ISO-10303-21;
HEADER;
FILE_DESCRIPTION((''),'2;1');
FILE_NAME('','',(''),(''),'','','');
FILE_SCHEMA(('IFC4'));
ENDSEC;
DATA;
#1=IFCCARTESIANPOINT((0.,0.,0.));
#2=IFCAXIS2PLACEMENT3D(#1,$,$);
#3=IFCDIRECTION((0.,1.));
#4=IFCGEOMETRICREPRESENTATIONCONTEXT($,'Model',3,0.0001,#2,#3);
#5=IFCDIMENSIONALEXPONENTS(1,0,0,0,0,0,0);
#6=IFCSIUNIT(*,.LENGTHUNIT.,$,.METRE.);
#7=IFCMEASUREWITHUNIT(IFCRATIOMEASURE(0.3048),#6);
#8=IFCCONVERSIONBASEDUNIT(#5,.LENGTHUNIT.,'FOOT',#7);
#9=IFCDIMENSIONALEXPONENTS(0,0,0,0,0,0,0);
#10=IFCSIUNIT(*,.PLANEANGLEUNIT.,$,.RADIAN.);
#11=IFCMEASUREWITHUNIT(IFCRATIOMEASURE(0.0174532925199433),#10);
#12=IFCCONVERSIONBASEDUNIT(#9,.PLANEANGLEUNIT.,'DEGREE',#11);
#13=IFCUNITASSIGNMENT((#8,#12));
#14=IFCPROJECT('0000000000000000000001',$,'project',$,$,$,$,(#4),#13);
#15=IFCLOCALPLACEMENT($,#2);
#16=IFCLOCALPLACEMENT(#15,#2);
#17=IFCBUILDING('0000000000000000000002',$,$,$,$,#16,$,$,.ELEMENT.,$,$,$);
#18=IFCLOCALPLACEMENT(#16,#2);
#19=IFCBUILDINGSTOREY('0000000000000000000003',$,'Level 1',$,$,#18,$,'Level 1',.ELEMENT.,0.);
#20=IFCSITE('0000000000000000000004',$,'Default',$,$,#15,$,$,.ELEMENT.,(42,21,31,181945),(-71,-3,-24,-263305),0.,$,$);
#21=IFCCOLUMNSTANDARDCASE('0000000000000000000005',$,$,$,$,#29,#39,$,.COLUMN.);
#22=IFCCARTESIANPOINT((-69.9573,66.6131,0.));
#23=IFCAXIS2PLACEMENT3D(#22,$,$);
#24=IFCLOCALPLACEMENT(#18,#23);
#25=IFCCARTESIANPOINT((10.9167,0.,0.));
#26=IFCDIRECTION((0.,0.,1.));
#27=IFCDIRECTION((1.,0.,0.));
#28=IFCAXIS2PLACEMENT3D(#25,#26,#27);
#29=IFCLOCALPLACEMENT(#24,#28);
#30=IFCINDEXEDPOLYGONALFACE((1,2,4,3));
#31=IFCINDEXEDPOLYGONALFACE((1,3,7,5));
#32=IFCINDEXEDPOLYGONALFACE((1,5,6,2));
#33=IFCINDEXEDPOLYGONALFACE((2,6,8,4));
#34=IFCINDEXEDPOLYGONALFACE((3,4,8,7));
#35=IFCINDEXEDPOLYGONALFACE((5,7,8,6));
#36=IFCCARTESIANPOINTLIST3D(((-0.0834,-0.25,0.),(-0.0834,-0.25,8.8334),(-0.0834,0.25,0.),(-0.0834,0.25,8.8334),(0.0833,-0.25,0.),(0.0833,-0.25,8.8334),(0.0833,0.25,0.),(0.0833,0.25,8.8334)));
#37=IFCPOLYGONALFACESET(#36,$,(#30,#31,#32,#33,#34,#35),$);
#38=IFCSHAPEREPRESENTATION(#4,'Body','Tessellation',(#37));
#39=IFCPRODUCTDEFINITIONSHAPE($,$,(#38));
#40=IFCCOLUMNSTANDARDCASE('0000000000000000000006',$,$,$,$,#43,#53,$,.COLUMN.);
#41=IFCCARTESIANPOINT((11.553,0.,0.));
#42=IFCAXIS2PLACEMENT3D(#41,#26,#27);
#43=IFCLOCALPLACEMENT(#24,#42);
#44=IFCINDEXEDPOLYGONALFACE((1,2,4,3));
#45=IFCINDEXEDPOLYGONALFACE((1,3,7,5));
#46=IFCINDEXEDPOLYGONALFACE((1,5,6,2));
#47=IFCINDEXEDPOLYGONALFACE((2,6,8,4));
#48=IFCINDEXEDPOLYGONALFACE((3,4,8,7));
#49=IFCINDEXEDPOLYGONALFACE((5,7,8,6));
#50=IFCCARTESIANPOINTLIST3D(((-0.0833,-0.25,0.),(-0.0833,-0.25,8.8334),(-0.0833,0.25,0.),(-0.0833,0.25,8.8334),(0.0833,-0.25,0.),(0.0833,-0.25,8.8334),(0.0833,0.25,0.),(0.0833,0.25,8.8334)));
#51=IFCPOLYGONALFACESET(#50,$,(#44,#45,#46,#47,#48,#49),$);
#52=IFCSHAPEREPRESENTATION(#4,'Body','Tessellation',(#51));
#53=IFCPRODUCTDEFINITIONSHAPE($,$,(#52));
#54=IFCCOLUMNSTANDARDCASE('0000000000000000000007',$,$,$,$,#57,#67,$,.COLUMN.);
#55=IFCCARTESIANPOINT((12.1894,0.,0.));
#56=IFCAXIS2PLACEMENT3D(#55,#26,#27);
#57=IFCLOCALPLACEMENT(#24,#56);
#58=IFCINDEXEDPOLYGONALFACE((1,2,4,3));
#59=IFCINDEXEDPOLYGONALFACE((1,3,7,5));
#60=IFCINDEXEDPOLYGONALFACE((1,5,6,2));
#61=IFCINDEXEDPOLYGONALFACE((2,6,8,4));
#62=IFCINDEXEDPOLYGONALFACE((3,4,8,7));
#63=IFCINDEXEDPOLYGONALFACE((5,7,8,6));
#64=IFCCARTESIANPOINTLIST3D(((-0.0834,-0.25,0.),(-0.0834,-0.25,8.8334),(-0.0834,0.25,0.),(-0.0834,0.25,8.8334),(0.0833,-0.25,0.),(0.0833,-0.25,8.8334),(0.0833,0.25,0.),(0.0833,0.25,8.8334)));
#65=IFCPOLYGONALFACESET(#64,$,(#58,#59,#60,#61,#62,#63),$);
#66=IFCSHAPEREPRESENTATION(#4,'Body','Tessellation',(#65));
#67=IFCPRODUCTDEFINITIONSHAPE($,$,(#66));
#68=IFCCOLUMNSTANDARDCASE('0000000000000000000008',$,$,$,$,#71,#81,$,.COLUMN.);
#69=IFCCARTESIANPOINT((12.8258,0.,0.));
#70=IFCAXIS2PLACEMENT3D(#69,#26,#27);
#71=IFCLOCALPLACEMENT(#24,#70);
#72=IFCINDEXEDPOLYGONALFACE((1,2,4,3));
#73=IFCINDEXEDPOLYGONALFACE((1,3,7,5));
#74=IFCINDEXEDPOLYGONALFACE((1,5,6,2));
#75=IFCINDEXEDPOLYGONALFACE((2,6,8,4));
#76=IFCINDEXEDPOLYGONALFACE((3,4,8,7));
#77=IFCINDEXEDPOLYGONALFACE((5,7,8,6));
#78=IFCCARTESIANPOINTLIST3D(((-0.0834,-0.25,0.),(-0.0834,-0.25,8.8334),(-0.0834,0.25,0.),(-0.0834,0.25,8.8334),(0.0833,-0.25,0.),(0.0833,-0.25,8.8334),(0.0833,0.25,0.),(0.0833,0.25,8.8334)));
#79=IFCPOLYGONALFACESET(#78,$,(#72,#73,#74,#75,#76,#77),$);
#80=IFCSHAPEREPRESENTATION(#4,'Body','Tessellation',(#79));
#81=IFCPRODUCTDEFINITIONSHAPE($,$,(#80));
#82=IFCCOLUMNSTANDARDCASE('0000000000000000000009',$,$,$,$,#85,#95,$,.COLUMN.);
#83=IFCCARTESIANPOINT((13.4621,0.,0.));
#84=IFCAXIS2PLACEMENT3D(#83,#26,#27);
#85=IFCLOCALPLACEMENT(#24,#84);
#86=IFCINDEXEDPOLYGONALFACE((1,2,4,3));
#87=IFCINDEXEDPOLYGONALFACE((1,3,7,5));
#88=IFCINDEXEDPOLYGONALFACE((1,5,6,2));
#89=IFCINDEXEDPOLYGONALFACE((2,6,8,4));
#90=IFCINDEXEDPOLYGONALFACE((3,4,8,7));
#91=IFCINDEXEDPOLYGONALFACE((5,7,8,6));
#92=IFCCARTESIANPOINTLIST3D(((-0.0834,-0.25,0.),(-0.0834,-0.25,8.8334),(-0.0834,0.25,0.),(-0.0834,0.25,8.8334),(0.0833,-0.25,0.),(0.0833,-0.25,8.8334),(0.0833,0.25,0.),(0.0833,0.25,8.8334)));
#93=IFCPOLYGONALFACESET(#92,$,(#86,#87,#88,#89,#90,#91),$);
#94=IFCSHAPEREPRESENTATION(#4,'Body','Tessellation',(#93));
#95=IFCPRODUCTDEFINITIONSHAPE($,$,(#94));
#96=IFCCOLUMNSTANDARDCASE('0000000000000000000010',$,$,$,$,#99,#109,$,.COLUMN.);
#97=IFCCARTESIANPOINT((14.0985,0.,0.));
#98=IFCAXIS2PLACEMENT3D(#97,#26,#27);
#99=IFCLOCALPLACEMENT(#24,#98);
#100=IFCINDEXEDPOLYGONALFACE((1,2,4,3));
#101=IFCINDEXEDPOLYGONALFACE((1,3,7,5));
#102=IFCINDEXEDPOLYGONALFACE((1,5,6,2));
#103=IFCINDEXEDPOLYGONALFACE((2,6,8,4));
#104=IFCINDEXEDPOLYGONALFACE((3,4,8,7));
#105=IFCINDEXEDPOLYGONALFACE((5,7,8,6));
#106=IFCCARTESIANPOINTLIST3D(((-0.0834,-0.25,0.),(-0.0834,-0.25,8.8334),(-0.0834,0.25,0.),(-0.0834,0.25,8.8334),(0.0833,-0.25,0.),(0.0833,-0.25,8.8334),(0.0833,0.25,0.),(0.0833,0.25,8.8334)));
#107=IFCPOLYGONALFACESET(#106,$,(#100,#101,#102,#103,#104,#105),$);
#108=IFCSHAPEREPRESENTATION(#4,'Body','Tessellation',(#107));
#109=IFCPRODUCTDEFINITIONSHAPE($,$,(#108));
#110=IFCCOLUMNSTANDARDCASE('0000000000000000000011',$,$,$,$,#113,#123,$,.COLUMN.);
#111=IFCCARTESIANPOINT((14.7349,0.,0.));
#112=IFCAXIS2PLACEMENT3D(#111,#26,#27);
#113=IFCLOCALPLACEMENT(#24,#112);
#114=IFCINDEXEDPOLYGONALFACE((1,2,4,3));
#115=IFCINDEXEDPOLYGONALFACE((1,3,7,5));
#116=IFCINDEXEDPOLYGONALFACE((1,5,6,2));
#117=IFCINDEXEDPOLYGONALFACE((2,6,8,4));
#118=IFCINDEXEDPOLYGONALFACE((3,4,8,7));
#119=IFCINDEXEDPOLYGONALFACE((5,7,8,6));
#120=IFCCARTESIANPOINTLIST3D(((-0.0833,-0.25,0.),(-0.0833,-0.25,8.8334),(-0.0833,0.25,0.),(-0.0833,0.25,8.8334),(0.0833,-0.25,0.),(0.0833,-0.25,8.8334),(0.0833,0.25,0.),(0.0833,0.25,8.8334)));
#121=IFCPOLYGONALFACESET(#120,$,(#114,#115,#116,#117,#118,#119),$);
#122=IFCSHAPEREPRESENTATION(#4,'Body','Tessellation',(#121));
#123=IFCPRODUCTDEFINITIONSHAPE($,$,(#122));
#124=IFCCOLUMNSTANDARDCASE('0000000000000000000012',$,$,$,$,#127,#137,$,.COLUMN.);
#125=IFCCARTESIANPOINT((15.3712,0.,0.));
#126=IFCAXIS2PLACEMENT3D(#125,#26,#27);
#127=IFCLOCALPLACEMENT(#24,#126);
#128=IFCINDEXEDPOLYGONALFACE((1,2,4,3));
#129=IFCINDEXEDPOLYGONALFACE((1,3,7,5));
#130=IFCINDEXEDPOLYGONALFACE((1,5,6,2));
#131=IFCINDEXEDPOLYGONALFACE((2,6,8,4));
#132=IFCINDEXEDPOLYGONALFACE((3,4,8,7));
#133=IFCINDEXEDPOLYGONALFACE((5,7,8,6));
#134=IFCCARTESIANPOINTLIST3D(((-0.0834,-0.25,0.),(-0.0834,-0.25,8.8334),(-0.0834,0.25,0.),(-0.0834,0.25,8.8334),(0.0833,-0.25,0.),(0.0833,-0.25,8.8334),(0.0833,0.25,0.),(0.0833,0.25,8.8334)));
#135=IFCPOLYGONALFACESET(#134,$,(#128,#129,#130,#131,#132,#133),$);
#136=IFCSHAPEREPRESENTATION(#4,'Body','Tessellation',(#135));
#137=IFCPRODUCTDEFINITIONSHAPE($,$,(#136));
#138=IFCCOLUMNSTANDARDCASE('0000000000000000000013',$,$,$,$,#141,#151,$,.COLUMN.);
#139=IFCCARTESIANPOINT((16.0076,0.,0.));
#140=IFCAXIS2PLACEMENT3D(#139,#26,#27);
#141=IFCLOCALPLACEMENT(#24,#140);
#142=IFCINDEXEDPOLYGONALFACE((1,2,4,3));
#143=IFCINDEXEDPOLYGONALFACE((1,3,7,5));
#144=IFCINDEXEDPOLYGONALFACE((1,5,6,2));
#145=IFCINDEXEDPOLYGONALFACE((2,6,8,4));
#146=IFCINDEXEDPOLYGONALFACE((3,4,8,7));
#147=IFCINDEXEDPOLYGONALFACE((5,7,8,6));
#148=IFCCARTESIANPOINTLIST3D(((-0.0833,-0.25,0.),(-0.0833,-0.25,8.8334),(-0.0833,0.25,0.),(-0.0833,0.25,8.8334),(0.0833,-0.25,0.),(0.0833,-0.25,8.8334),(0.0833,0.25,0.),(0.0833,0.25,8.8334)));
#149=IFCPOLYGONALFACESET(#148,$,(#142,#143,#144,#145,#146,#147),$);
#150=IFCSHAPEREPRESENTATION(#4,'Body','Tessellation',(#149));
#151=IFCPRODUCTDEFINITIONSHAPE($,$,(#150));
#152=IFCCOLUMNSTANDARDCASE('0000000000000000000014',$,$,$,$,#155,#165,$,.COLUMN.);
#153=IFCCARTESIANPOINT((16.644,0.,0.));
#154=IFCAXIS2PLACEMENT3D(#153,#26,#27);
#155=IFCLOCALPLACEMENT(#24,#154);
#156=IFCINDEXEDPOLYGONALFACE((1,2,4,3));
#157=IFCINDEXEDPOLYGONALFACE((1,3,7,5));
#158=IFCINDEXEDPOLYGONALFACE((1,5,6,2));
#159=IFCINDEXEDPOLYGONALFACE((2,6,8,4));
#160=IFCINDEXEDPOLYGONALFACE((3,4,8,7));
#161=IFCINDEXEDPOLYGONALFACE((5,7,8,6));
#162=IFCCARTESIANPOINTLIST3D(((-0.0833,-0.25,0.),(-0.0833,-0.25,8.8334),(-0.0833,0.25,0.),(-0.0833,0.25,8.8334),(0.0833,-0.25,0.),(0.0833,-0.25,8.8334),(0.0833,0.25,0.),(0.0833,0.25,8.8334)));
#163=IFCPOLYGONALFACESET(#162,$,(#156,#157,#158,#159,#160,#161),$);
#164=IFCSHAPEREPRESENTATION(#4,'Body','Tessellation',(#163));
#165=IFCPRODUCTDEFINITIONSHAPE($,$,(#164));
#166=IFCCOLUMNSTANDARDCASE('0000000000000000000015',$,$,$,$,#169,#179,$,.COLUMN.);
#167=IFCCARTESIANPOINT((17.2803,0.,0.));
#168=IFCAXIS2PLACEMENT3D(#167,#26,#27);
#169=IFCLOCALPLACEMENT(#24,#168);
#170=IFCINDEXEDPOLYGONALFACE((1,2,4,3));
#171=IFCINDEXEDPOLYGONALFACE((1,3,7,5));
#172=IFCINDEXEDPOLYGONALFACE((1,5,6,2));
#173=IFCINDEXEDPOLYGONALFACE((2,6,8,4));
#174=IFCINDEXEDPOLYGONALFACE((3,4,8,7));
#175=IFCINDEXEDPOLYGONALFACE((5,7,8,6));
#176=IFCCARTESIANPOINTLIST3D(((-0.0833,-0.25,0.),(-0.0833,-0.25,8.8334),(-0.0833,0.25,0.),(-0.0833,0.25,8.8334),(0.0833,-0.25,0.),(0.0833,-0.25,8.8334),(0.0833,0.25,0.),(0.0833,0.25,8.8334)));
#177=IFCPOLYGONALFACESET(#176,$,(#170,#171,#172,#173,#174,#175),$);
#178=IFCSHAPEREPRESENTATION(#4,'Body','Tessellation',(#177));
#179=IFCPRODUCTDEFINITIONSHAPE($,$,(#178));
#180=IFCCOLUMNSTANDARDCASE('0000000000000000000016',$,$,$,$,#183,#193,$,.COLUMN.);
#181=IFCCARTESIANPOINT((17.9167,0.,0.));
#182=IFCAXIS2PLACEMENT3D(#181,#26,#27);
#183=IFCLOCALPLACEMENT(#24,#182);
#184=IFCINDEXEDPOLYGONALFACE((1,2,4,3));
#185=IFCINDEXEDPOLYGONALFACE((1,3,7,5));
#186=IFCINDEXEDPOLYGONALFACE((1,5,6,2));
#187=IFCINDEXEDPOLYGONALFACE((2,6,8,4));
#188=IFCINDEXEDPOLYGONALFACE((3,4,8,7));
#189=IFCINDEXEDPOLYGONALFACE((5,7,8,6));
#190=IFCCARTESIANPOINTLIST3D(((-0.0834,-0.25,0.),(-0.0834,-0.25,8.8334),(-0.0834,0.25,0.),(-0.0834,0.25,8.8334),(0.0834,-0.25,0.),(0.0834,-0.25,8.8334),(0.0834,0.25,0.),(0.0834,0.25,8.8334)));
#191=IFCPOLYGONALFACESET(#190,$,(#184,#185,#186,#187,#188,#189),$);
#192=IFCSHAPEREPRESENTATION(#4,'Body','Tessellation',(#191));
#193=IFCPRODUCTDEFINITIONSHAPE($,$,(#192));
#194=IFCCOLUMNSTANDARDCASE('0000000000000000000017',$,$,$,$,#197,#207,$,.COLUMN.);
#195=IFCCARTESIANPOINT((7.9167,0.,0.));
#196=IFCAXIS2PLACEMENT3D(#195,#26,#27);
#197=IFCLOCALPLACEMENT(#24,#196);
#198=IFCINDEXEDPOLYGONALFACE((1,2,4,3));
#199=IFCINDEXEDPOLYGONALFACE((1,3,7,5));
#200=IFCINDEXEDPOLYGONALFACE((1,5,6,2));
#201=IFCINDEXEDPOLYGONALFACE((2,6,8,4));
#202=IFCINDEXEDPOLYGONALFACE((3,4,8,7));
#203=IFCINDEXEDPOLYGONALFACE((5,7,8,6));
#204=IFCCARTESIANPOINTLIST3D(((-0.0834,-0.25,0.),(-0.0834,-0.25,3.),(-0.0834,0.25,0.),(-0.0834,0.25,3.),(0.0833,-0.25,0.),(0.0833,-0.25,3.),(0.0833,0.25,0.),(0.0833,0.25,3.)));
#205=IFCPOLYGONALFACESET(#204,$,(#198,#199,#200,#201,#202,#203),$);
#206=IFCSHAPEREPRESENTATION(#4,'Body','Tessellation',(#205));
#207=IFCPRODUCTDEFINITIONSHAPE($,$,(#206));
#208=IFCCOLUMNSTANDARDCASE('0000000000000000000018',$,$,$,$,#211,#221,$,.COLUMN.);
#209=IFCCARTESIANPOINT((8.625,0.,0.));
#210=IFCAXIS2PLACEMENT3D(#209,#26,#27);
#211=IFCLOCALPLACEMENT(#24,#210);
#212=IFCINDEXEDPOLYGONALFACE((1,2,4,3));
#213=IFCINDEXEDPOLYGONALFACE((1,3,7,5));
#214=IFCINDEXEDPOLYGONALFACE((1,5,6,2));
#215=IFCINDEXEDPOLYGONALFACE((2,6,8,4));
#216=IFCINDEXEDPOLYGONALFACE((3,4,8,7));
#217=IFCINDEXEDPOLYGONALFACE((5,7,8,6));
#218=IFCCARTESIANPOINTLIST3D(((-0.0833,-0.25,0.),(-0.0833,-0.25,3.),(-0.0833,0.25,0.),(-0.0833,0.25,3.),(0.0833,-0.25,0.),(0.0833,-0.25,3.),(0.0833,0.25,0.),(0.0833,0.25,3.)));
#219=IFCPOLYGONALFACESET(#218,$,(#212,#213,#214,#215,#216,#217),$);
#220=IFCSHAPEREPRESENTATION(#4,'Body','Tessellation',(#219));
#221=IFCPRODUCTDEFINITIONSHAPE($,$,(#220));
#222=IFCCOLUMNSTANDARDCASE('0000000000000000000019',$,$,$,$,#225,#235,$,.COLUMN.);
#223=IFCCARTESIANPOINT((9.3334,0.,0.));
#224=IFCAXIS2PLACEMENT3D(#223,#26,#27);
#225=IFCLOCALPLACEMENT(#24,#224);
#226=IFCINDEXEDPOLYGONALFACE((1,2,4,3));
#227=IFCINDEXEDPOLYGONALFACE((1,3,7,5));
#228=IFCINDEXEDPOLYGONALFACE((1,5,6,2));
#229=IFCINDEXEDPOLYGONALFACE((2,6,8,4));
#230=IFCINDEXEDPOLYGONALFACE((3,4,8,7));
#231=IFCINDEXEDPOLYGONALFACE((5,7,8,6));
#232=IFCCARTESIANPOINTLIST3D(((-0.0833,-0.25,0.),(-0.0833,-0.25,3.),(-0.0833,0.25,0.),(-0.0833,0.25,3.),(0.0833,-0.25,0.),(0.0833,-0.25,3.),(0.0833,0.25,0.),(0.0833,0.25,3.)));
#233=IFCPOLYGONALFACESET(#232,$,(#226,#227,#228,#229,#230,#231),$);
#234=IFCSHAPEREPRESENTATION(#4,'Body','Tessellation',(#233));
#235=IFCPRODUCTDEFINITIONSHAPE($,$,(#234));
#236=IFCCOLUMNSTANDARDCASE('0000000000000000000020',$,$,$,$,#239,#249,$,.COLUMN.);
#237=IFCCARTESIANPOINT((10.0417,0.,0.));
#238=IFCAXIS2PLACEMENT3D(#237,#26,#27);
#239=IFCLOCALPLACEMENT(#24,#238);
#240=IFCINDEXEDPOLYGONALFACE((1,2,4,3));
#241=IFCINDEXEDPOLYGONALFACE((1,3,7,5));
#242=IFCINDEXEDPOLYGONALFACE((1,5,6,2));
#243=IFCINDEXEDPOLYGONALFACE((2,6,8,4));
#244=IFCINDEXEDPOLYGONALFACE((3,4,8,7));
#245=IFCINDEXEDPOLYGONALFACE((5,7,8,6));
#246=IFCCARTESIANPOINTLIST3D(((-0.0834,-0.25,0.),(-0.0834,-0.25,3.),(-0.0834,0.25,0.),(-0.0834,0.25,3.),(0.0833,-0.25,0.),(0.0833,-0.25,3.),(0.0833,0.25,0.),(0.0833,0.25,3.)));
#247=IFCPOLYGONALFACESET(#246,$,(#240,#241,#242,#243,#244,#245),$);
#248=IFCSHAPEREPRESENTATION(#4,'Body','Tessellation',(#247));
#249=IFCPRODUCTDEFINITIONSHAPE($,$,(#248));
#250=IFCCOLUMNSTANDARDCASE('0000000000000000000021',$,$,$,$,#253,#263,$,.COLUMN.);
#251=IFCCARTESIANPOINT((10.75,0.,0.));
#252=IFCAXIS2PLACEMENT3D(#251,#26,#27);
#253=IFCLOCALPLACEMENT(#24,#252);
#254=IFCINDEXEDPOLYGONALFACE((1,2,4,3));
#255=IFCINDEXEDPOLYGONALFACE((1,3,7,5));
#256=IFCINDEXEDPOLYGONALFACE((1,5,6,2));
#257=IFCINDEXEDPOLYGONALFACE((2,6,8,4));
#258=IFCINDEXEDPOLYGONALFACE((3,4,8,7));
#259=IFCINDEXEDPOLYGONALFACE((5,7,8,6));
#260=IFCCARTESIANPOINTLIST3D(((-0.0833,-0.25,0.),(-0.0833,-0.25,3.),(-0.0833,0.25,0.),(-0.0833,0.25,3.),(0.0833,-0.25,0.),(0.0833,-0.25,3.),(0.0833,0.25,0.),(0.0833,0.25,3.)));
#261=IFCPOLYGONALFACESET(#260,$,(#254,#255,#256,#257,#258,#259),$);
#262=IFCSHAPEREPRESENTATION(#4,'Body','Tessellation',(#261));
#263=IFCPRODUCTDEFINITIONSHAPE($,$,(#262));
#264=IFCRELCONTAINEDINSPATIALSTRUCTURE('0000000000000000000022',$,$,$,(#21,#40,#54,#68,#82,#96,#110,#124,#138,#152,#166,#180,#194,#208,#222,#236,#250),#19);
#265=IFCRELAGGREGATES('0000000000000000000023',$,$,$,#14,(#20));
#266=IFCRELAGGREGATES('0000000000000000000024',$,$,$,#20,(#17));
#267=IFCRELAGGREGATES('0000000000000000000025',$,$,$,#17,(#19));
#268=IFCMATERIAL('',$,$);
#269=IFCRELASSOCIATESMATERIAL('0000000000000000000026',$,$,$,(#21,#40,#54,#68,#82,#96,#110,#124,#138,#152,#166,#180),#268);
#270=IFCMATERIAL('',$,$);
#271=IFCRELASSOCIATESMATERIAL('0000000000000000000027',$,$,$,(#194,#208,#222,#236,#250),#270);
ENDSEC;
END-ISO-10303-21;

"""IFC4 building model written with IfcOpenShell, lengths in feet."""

from ifc_helpers import new_model, entity, si_unit, converted_unit, direction, frame, origin, place, context, project, spatial, rectangle, extrude, material, element, save


model = new_model("IFC4")

# Units and contexts
model_context = context("Model", 3, precision=0.0001, world=origin(), true_north=direction((0.0, 1.0)))
ifc_project = project(units=[converted_unit("LENGTHUNIT", "FOOT", entity("IfcRatioMeasure", 0.3048), si_unit("LENGTHUNIT", "METRE"), dimensions=[1, 0, 0, 0, 0, 0, 0]), converted_unit("PLANEANGLEUNIT", "DEGREE", entity("IfcRatioMeasure", 0.0174532925199433), si_unit("PLANEANGLEUNIT", "RADIAN"), dimensions=[0, 0, 0, 0, 0, 0, 0])], contexts=[model_context])

# Site, building, storey
site_placement = place(None, origin())
site = spatial("IfcSite", under=ifc_project, at=site_placement, Name="Default", CompositionType="ELEMENT", RefLatitude=(42, 21, 31, 181945), RefLongitude=(-71, -3, -24, -263305), RefElevation=0.0)
building_placement = place(site_placement, origin())
building = spatial("IfcBuilding", under=site, at=building_placement, CompositionType="ELEMENT")
storey_placement = place(building_placement, origin())
storey = spatial("IfcBuildingStorey", under=building, at=storey_placement, Name="Level 1", LongName="Level 1", CompositionType="ELEMENT", Elevation=0.0)

# Columns
placement_1 = place(storey_placement, frame((-69.9573, 66.6131, 0.0)))
ifc_material_1 = material(Name="")
for number, where, z_axis, x_axis in (
    (1, (10.9167, 0.0, 0.0), (0.0, 0.0, 1.0), (1.0, 0.0, 0.0)),
    (2, (11.553, 0.0, 0.0), (0.0, 0.0, 1.0), (1.0, 0.0, 0.0)),
    (3, (12.1894, 0.0, 0.0), (0.0, 0.0, 1.0), (1.0, 0.0, 0.0)),
    (4, (12.8258, 0.0, 0.0), (0.0, 0.0, 1.0), (1.0, 0.0, 0.0)),
    (5, (13.4621, 0.0, 0.0), (0.0, 0.0, 1.0), (1.0, 0.0, 0.0)),
    (6, (14.0985, 0.0, 0.0), (0.0, 0.0, 1.0), (1.0, 0.0, 0.0)),
    (7, (14.7349, 0.0, 0.0), (0.0, 0.0, 1.0), (1.0, 0.0, 0.0)),
    (8, (15.3712, 0.0, 0.0), (0.0, 0.0, 1.0), (1.0, 0.0, 0.0)),
    (9, (16.0076, 0.0, 0.0), (0.0, 0.0, 1.0), (1.0, 0.0, 0.0)),
    (10, (16.644, 0.0, 0.0), (0.0, 0.0, 1.0), (1.0, 0.0, 0.0)),
    (11, (17.2803, 0.0, 0.0), (0.0, 0.0, 1.0), (1.0, 0.0, 0.0)),
    (12, (17.9167, 0.0, 0.0), (0.0, 0.0, 1.0), (1.0, 0.0, 0.0)),
):
    element("IfcColumnStandardCase", number, at=place(placement_1, frame(where, z_axis=z_axis, x_axis=x_axis)), inside=storey, material=ifc_material_1, PredefinedType="COLUMN", context=model_context, shape_type="SweptSolid", body=[
        extrude(rectangle(XDim=0.1667, YDim=0.5), origin(), (0.0, 0.0, 1.0), 8.8334),
    ])
ifc_material_2 = material(Name="")
for number, where, z_axis, x_axis in (
    (13, (7.9167, 0.0, 0.0), (0.0, 0.0, 1.0), (1.0, 0.0, 0.0)),
    (14, (8.625, 0.0, 0.0), (0.0, 0.0, 1.0), (1.0, 0.0, 0.0)),
    (15, (9.3334, 0.0, 0.0), (0.0, 0.0, 1.0), (1.0, 0.0, 0.0)),
    (16, (10.0417, 0.0, 0.0), (0.0, 0.0, 1.0), (1.0, 0.0, 0.0)),
    (17, (10.75, 0.0, 0.0), (0.0, 0.0, 1.0), (1.0, 0.0, 0.0)),
):
    element("IfcColumnStandardCase", number, at=place(placement_1, frame(where, z_axis=z_axis, x_axis=x_axis)), inside=storey, material=ifc_material_2, PredefinedType="COLUMN", context=model_context, shape_type="SweptSolid", body=[
        extrude(rectangle(XDim=0.1667, YDim=0.5), origin(), (0.0, 0.0, 1.0), 3.0),
    ])

save(model, "model.ifc")
